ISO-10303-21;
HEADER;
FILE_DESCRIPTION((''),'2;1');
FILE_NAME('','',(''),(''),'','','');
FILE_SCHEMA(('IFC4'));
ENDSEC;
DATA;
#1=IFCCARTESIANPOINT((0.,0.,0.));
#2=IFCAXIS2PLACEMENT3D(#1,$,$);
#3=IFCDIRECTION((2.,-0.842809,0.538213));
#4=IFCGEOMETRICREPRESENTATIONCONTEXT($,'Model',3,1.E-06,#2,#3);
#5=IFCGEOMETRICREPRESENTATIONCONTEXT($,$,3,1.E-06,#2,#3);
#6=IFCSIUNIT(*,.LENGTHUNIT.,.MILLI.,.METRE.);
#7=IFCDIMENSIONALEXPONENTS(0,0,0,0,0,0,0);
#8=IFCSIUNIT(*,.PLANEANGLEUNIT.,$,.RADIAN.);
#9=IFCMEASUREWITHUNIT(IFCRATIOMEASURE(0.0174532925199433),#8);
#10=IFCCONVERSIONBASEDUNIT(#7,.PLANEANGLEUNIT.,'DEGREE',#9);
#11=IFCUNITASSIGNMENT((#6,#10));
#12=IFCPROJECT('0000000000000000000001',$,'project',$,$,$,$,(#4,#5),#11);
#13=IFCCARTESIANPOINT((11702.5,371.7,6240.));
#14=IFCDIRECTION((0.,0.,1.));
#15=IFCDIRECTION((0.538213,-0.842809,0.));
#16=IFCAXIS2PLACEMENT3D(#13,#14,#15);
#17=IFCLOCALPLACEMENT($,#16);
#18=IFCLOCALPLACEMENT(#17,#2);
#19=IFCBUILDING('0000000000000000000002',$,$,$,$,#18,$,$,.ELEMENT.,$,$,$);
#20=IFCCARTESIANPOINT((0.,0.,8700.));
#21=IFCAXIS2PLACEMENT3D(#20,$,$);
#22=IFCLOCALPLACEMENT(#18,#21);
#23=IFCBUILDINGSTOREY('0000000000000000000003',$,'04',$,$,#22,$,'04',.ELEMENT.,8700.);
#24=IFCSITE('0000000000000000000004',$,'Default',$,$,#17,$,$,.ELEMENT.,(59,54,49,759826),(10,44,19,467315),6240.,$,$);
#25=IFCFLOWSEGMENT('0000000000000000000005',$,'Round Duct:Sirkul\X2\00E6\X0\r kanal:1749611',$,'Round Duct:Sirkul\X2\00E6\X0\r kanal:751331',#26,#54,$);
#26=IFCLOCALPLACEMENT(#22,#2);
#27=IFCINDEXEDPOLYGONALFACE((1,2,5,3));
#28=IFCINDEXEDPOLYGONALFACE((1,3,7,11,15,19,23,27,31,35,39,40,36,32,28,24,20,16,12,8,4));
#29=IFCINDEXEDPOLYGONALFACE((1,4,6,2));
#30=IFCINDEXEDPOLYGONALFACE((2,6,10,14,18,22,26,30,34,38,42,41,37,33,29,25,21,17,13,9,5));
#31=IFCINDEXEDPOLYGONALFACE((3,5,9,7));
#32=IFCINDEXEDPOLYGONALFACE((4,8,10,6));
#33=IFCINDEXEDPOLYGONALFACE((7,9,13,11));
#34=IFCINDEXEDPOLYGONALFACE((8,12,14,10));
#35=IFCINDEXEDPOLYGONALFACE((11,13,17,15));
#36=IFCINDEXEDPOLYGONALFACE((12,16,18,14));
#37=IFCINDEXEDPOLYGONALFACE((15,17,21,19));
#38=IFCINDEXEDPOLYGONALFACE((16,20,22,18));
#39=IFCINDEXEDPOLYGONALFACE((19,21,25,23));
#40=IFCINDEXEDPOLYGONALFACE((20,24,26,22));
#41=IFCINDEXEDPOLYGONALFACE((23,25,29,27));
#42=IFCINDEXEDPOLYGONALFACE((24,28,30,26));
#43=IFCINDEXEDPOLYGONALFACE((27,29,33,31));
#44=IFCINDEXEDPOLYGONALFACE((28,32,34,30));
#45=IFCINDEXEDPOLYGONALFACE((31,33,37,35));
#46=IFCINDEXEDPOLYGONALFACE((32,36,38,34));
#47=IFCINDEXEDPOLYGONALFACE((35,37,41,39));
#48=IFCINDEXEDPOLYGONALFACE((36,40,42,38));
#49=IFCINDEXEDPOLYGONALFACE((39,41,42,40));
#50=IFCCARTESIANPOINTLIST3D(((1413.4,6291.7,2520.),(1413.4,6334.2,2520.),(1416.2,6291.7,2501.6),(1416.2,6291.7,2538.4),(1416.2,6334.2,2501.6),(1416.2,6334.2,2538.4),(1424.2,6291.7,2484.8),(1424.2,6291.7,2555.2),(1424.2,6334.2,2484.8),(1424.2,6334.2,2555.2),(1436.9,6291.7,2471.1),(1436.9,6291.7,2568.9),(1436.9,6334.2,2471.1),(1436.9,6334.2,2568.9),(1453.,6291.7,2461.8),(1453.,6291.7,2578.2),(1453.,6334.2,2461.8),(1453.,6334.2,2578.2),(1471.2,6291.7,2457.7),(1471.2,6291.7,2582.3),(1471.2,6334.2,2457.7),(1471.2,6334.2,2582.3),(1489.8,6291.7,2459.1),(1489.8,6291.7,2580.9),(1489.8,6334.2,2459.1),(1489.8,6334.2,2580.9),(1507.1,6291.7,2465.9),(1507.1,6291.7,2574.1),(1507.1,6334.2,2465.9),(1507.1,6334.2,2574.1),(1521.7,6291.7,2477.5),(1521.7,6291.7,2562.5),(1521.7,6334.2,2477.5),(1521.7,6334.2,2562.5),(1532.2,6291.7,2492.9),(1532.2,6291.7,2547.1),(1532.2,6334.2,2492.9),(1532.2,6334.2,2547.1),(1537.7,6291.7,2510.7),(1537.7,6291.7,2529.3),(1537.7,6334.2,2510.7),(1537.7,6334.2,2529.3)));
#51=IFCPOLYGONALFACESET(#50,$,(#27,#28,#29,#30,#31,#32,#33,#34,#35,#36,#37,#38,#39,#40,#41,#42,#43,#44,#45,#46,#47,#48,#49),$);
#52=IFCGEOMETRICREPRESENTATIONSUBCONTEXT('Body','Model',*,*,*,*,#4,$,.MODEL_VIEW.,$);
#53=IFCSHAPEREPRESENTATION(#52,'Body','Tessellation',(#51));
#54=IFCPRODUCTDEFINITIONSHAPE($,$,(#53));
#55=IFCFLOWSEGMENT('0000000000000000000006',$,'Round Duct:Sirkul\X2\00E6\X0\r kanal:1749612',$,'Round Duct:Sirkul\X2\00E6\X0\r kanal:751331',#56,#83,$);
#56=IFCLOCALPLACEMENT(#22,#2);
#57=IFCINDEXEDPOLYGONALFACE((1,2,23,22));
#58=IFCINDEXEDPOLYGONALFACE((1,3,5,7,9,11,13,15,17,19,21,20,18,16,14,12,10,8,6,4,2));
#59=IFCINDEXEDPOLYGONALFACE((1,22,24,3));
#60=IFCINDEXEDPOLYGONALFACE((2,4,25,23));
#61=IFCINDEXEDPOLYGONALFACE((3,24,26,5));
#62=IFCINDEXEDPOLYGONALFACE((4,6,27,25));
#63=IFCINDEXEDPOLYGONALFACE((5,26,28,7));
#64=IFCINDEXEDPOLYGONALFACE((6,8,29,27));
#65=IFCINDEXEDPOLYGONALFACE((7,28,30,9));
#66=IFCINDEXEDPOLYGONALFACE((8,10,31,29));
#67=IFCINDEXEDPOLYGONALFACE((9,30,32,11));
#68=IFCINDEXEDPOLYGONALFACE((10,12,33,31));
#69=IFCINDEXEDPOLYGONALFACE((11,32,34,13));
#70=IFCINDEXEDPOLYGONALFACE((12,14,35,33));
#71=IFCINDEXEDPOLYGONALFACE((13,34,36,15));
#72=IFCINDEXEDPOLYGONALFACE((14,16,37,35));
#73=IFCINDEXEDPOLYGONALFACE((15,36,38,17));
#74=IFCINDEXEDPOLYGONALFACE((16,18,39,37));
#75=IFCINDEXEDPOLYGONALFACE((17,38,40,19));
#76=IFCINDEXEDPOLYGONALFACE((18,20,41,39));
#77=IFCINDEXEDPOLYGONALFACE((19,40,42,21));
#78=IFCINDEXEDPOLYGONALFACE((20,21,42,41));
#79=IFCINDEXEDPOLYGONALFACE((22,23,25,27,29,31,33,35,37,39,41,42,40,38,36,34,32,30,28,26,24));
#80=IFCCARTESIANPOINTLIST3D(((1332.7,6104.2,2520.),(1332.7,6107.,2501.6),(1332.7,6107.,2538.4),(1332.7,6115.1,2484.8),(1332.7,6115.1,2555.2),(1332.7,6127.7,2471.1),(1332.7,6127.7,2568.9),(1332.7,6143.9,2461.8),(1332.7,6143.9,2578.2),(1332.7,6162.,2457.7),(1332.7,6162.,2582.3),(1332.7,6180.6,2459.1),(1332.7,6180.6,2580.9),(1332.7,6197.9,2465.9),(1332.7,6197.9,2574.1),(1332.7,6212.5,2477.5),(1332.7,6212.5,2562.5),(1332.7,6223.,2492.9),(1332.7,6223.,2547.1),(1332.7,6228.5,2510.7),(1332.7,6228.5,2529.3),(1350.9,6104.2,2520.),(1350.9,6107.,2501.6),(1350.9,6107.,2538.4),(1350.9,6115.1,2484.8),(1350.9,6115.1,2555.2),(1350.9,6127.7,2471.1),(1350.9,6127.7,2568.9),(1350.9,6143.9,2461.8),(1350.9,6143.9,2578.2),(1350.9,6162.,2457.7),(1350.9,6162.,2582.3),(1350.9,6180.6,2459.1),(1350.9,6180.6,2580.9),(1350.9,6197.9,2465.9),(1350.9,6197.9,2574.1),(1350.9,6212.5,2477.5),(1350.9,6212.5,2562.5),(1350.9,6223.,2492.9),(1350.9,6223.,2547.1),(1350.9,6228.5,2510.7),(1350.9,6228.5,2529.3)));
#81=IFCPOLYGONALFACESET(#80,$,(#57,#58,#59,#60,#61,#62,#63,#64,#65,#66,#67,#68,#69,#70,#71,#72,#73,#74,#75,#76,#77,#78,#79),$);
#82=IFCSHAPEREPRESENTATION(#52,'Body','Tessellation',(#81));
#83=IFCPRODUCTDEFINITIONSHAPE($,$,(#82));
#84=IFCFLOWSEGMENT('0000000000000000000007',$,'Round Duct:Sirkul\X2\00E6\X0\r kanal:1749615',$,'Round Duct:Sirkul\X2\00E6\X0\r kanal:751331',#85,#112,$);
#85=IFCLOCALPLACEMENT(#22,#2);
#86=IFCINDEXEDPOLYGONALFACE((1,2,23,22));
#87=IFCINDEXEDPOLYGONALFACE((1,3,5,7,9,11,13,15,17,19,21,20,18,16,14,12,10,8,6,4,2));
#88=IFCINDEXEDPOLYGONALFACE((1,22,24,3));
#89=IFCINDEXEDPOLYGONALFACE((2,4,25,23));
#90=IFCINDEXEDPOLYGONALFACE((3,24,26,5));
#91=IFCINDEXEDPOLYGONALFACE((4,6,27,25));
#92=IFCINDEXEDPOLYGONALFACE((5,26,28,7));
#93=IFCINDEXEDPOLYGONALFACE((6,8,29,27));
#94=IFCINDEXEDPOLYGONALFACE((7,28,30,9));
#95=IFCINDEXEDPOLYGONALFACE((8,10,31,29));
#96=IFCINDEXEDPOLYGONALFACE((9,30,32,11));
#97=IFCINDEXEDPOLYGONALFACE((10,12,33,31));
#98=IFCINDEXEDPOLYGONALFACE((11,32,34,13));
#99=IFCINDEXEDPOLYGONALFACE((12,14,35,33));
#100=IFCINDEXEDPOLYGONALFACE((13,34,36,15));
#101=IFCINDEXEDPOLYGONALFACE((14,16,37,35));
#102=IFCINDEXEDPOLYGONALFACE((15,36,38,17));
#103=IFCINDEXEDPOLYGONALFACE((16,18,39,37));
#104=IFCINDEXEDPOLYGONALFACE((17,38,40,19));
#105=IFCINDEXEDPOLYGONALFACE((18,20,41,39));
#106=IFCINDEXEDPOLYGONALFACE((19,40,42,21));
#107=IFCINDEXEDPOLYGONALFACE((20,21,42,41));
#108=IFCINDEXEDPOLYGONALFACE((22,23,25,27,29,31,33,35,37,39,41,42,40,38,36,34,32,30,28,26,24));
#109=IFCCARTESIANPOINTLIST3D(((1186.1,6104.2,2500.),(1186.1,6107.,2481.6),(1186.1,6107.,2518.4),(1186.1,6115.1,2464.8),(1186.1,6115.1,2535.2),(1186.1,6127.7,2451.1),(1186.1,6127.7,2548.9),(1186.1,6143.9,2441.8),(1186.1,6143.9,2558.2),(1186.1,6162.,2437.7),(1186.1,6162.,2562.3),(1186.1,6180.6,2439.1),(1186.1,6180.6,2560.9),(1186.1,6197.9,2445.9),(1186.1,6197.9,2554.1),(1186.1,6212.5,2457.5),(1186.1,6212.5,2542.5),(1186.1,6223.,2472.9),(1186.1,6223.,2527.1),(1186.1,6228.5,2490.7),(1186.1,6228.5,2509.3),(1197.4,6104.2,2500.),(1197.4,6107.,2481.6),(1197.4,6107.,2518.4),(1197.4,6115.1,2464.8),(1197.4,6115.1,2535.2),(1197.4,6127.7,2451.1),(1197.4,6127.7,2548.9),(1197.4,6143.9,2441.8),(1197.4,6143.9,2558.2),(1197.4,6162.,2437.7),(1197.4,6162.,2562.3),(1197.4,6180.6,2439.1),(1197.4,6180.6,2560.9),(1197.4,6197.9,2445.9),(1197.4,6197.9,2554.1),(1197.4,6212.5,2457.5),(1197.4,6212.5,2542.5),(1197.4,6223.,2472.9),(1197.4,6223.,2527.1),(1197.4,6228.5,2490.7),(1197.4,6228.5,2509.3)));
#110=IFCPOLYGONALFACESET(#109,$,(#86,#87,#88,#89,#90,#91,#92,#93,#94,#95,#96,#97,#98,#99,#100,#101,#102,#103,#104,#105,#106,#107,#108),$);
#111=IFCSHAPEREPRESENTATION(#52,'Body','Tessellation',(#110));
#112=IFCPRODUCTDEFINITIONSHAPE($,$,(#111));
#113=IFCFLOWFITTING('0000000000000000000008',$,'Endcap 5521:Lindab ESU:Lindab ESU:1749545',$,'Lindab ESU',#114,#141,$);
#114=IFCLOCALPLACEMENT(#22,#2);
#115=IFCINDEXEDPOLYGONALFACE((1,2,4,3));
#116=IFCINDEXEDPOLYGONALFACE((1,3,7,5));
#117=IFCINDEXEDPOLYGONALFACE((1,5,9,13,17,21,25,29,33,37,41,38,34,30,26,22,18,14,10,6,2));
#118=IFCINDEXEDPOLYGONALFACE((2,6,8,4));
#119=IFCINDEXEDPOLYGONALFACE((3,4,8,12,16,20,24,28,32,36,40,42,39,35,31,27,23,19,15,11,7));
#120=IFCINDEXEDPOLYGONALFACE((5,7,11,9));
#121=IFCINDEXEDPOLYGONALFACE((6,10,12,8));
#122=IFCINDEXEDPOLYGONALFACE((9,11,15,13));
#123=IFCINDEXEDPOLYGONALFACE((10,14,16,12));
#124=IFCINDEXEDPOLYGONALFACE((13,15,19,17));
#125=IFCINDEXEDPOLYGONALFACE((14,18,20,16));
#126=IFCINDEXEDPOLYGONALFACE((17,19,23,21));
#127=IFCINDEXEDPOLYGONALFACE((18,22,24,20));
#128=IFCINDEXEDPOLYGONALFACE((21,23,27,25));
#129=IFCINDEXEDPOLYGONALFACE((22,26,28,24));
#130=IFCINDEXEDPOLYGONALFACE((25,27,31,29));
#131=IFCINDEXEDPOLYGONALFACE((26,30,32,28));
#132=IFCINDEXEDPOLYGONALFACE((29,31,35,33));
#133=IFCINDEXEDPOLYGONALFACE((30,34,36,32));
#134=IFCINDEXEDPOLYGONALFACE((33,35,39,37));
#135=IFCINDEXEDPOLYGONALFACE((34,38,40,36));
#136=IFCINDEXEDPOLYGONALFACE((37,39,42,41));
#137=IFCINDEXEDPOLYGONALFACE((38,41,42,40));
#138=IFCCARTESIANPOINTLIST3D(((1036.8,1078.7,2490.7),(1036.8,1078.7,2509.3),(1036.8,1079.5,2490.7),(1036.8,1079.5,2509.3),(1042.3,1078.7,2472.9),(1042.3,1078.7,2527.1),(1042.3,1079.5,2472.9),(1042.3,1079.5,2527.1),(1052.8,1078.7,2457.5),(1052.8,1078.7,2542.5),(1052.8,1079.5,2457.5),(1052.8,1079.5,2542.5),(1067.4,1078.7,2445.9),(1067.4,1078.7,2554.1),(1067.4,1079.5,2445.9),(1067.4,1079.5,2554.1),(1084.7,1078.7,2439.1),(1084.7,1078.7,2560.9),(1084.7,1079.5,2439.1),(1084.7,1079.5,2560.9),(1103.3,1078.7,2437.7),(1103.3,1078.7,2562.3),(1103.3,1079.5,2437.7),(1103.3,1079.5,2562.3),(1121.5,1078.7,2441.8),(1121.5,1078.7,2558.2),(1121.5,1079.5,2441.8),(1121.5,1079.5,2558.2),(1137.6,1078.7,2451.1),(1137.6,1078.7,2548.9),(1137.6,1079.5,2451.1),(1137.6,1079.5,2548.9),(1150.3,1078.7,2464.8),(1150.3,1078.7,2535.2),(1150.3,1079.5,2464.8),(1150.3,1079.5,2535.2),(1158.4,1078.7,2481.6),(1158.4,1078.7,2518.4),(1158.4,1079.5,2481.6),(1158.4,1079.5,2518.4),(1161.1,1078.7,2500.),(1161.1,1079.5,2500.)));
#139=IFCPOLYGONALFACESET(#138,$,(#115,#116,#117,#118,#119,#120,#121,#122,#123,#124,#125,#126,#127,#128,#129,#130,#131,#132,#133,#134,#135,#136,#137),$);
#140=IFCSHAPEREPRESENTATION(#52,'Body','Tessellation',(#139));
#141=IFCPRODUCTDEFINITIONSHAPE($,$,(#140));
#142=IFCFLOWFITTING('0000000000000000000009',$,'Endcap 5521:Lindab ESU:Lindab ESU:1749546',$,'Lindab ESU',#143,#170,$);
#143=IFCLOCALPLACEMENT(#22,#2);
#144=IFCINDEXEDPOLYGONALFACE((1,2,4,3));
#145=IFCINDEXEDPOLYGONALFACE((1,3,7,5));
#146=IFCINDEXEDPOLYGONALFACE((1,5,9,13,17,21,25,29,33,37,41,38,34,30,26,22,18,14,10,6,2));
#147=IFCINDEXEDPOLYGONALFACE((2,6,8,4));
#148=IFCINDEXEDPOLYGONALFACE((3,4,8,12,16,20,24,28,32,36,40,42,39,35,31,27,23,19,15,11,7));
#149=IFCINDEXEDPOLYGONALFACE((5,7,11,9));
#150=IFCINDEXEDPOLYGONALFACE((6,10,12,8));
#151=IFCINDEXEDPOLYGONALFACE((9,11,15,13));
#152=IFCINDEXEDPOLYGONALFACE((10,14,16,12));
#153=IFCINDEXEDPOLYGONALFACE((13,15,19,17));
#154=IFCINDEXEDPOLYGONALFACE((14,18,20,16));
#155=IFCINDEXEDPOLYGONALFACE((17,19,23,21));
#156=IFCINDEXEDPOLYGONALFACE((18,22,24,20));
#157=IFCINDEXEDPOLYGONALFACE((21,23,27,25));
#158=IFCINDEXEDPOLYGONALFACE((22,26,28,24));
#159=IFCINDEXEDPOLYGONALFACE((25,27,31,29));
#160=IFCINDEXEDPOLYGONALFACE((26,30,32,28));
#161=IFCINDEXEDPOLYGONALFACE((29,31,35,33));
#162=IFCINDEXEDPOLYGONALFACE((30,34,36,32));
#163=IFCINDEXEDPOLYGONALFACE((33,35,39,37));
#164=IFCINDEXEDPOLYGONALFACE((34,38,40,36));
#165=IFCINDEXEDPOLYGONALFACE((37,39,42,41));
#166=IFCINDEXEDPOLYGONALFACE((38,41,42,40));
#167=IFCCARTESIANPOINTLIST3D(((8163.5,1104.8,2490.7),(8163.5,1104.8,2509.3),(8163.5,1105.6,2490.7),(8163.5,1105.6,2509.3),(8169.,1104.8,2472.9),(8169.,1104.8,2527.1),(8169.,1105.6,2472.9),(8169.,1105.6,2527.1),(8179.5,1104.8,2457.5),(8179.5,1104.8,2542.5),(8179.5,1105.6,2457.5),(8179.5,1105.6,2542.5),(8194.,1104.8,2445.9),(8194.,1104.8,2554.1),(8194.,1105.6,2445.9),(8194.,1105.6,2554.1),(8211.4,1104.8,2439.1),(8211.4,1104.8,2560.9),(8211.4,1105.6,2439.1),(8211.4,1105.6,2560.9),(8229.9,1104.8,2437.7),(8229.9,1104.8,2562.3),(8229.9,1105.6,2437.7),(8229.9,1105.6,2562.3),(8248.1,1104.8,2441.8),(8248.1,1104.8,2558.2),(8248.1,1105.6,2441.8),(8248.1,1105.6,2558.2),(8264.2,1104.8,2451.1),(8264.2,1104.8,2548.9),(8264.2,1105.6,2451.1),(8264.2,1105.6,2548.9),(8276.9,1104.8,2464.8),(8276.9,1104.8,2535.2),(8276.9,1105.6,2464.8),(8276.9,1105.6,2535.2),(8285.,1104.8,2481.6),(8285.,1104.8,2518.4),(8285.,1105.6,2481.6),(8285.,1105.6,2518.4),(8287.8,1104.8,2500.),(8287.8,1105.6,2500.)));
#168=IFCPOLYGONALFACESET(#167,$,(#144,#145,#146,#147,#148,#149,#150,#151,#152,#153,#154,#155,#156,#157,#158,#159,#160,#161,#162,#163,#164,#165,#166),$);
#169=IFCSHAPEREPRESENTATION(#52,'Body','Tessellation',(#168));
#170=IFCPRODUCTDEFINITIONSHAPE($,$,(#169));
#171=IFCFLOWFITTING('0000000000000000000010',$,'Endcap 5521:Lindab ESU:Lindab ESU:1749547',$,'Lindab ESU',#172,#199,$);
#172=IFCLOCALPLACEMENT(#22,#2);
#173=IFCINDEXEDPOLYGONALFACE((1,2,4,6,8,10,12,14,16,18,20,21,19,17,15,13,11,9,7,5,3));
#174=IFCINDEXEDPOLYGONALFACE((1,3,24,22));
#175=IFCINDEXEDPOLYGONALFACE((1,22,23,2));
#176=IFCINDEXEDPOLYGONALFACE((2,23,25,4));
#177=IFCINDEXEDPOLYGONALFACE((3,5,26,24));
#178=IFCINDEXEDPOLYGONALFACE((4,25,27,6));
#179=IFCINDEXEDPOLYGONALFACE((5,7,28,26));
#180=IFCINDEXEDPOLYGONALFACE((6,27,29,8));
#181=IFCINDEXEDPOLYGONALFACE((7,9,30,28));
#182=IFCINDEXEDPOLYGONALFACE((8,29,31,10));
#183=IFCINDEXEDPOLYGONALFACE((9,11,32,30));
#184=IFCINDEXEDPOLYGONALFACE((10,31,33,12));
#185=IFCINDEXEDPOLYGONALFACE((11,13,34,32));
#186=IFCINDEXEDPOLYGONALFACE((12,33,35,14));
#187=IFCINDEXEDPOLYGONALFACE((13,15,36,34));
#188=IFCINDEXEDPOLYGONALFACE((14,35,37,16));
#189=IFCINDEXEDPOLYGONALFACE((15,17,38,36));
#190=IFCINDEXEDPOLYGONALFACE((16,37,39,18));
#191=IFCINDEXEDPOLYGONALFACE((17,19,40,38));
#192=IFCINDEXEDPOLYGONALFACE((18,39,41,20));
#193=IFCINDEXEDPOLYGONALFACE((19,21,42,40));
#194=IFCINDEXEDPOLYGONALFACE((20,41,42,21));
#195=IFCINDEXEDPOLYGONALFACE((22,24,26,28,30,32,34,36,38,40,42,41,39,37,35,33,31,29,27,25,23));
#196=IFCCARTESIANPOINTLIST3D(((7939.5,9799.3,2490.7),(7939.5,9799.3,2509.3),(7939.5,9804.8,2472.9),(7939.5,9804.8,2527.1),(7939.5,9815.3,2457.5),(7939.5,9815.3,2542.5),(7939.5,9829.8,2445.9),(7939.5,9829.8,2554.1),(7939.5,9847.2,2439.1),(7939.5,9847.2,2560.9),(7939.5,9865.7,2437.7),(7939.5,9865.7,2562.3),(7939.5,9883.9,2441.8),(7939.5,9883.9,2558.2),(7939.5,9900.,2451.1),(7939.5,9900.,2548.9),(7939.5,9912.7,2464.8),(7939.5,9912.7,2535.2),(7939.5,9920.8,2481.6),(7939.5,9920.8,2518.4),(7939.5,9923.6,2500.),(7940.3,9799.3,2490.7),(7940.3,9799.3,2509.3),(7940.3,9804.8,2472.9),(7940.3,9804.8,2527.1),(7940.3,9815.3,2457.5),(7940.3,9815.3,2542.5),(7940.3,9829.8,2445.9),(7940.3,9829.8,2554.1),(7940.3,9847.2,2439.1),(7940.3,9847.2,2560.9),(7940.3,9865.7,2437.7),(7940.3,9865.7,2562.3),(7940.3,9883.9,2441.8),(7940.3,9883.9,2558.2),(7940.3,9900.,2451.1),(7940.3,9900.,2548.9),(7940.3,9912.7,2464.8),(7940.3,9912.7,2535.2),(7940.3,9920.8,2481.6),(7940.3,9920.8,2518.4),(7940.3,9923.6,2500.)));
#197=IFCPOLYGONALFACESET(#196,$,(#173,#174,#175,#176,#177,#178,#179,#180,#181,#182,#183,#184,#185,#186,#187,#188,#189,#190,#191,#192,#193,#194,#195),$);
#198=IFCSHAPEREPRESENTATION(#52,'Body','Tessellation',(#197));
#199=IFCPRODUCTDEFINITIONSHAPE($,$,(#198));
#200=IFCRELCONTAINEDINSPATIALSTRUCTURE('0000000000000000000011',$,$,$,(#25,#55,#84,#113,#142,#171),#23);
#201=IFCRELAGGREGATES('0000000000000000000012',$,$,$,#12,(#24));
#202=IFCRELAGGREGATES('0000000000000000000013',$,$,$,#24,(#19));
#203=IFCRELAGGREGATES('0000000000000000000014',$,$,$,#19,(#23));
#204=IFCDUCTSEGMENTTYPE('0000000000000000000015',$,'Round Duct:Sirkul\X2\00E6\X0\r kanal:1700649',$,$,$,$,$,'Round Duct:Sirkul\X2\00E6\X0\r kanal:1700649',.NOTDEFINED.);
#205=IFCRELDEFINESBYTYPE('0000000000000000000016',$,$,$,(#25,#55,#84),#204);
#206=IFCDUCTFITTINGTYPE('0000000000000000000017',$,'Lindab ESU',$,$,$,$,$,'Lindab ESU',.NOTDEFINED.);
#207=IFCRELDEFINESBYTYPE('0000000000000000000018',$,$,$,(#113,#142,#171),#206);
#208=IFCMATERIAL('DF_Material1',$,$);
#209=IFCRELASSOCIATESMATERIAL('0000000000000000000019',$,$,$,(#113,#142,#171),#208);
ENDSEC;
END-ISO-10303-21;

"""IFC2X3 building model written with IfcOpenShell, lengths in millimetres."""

from ifc_helpers import new_model, entity, si_unit, converted_unit, direction, frame, frame_2d, origin, origin_2d_with_axis, place, context, subcontext, project, spatial, circle, extrude, source, transform, mapped, material, type_object, type_shapes, element, save


model = new_model("IFC2X3")

# Units and contexts
model_context = context("Model", 3, precision=1e-06, world=origin(), true_north=direction((2.0, -0.842809, 0.538213)))
context_of_model = context(None, 3, precision=1e-06, world=origin(), true_north=direction((2.0, -0.842809, 0.538213)))
body_context = subcontext(model_context, "Body", "Model", "MODEL_VIEW")
ifc_project = project(units=[si_unit("LENGTHUNIT", "METRE", prefix="MILLI"), converted_unit("PLANEANGLEUNIT", "DEGREE", entity("IfcRatioMeasure", 0.0174532925199433), si_unit("PLANEANGLEUNIT", "RADIAN"), dimensions=[0, 0, 0, 0, 0, 0, 0])], contexts=[model_context, context_of_model])

# Site, building, storey
site_placement = place(None, frame((11702.5, 371.7, 6240.0), z_axis=(0.0, 0.0, 1.0), x_axis=(0.538213, -0.842809, 0.0)))
site = spatial("IfcSite", under=ifc_project, at=site_placement, Name="Default", CompositionType="ELEMENT", RefLatitude=(59, 54, 49, 759826), RefLongitude=(10, 44, 19, 467315), RefElevation=6240.0)
building_placement = place(site_placement, origin())
building = spatial("IfcBuilding", under=site, at=building_placement, CompositionType="ELEMENT")
storey_placement = place(building_placement, frame((0.0, 0.0, 8700.0)))
storey = spatial("IfcBuildingStorey", under=building, at=storey_placement, Name="04", LongName="04", CompositionType="ELEMENT", Elevation=8700.0)

# Flow segments
duct_segment_type_1 = type_object("IfcDuctSegmentType", Name="Round Duct:Sirkulær kanal:1700649", ElementType="Round Duct:Sirkulær kanal:1700649", PredefinedType="NOTDEFINED")
flow_segment_1_placement = place(storey_placement, origin())
element("IfcFlowSegment", 1, at=flow_segment_1_placement, inside=storey, type_object=duct_segment_type_1, Name="Round Duct:Sirkulær kanal:1749611", ObjectType="Round Duct:Sirkulær kanal:751331", context=body_context, shape_type="SweptSolid", body=[
    extrude(circle(Radius=62.5, at=frame_2d((0.0, 0.0), x_axis=(1.0, 0.0))), frame((1475.9, 6291.7, 2520.0), z_axis=(0.0, 1.0, 0.0), x_axis=(-1.0, 0.0, 0.0)), (0.0, 0.0, 1.0), 42.5),
])
flow_segment_2_placement = place(storey_placement, origin())
element("IfcFlowSegment", 2, at=flow_segment_2_placement, inside=storey, type_object=duct_segment_type_1, Name="Round Duct:Sirkulær kanal:1749612", ObjectType="Round Duct:Sirkulær kanal:751331", context=body_context, shape_type="SweptSolid", body=[
    extrude(circle(Radius=62.5, at=origin_2d_with_axis()), frame((1332.7, 6166.7, 2520.0), z_axis=(1.0, 0.0, 0.0), x_axis=(0.0, -1.0, 0.0)), (0.0, 0.0, 1.0), 18.1),
])
flow_segment_3_placement = place(storey_placement, origin())
element("IfcFlowSegment", 3, at=flow_segment_3_placement, inside=storey, type_object=duct_segment_type_1, Name="Round Duct:Sirkulær kanal:1749615", ObjectType="Round Duct:Sirkulær kanal:751331", context=body_context, shape_type="SweptSolid", body=[
    extrude(circle(Radius=62.5, at=origin_2d_with_axis()), frame((1186.1, 6166.7, 2500.0), z_axis=(1.0, 0.0, 0.0), x_axis=(0.0, -1.0, 0.0)), (0.0, 0.0, 1.0), 11.3),
])

# Flow fittings
ifc_material = material(Name="DF_Material1")
duct_fitting_type = type_object("IfcDuctFittingType", Name="Lindab ESU", ElementType="Lindab ESU", PredefinedType="NOTDEFINED")
shared_shape_1 = source(origin(), body_context, "Body", "SweptSolid", [
    extrude(circle(Radius=62.5, at=frame_2d((0.0, 0.0), x_axis=(1.0, 0.0))), frame((0.0, 0.0, 0.0), z_axis=(1.0, 0.0, 0.0), x_axis=(0.0, 1.0, 0.0)), (0.0, 0.0, 1.0), 0.8),
])
type_shapes(duct_fitting_type, [shared_shape_1])
for number, where, z_axis, x_axis, name in (
    (4, (1098.6, 1079.5, 2500.0), (0.0, 0.0, 1.0), (0.0, -1.0, 0.0), "Endcap 5521:Lindab ESU:Lindab ESU:1749545"),
    (5, (8225.3, 1105.6, 2500.0), (0.0, 0.0, 1.0), (0.0, -1.0, 0.0), "Endcap 5521:Lindab ESU:Lindab ESU:1749546"),
):
    element("IfcFlowFitting", number, at=place(storey_placement, frame(where, z_axis=z_axis, x_axis=x_axis)), inside=storey, type_object=duct_fitting_type, material=ifc_material, Name=name, ObjectType="Lindab ESU", context=body_context, shape_type="MappedRepresentation", body=[
        mapped(shared_shape_1, transform((0.0, 0.0, 0.0), scale=1.0)),
    ])
flow_fitting_placement = place(storey_placement, frame((7939.5, 9861.1, 2500.0)))
element("IfcFlowFitting", 6, at=flow_fitting_placement, inside=storey, type_object=duct_fitting_type, material=ifc_material, Name="Endcap 5521:Lindab ESU:Lindab ESU:1749547", ObjectType="Lindab ESU", context=body_context, shape_type="MappedRepresentation", body=[
    mapped(shared_shape_1, transform((0.0, 0.0, 0.0), scale=1.0)),
])

save(model, "model.ifc")
